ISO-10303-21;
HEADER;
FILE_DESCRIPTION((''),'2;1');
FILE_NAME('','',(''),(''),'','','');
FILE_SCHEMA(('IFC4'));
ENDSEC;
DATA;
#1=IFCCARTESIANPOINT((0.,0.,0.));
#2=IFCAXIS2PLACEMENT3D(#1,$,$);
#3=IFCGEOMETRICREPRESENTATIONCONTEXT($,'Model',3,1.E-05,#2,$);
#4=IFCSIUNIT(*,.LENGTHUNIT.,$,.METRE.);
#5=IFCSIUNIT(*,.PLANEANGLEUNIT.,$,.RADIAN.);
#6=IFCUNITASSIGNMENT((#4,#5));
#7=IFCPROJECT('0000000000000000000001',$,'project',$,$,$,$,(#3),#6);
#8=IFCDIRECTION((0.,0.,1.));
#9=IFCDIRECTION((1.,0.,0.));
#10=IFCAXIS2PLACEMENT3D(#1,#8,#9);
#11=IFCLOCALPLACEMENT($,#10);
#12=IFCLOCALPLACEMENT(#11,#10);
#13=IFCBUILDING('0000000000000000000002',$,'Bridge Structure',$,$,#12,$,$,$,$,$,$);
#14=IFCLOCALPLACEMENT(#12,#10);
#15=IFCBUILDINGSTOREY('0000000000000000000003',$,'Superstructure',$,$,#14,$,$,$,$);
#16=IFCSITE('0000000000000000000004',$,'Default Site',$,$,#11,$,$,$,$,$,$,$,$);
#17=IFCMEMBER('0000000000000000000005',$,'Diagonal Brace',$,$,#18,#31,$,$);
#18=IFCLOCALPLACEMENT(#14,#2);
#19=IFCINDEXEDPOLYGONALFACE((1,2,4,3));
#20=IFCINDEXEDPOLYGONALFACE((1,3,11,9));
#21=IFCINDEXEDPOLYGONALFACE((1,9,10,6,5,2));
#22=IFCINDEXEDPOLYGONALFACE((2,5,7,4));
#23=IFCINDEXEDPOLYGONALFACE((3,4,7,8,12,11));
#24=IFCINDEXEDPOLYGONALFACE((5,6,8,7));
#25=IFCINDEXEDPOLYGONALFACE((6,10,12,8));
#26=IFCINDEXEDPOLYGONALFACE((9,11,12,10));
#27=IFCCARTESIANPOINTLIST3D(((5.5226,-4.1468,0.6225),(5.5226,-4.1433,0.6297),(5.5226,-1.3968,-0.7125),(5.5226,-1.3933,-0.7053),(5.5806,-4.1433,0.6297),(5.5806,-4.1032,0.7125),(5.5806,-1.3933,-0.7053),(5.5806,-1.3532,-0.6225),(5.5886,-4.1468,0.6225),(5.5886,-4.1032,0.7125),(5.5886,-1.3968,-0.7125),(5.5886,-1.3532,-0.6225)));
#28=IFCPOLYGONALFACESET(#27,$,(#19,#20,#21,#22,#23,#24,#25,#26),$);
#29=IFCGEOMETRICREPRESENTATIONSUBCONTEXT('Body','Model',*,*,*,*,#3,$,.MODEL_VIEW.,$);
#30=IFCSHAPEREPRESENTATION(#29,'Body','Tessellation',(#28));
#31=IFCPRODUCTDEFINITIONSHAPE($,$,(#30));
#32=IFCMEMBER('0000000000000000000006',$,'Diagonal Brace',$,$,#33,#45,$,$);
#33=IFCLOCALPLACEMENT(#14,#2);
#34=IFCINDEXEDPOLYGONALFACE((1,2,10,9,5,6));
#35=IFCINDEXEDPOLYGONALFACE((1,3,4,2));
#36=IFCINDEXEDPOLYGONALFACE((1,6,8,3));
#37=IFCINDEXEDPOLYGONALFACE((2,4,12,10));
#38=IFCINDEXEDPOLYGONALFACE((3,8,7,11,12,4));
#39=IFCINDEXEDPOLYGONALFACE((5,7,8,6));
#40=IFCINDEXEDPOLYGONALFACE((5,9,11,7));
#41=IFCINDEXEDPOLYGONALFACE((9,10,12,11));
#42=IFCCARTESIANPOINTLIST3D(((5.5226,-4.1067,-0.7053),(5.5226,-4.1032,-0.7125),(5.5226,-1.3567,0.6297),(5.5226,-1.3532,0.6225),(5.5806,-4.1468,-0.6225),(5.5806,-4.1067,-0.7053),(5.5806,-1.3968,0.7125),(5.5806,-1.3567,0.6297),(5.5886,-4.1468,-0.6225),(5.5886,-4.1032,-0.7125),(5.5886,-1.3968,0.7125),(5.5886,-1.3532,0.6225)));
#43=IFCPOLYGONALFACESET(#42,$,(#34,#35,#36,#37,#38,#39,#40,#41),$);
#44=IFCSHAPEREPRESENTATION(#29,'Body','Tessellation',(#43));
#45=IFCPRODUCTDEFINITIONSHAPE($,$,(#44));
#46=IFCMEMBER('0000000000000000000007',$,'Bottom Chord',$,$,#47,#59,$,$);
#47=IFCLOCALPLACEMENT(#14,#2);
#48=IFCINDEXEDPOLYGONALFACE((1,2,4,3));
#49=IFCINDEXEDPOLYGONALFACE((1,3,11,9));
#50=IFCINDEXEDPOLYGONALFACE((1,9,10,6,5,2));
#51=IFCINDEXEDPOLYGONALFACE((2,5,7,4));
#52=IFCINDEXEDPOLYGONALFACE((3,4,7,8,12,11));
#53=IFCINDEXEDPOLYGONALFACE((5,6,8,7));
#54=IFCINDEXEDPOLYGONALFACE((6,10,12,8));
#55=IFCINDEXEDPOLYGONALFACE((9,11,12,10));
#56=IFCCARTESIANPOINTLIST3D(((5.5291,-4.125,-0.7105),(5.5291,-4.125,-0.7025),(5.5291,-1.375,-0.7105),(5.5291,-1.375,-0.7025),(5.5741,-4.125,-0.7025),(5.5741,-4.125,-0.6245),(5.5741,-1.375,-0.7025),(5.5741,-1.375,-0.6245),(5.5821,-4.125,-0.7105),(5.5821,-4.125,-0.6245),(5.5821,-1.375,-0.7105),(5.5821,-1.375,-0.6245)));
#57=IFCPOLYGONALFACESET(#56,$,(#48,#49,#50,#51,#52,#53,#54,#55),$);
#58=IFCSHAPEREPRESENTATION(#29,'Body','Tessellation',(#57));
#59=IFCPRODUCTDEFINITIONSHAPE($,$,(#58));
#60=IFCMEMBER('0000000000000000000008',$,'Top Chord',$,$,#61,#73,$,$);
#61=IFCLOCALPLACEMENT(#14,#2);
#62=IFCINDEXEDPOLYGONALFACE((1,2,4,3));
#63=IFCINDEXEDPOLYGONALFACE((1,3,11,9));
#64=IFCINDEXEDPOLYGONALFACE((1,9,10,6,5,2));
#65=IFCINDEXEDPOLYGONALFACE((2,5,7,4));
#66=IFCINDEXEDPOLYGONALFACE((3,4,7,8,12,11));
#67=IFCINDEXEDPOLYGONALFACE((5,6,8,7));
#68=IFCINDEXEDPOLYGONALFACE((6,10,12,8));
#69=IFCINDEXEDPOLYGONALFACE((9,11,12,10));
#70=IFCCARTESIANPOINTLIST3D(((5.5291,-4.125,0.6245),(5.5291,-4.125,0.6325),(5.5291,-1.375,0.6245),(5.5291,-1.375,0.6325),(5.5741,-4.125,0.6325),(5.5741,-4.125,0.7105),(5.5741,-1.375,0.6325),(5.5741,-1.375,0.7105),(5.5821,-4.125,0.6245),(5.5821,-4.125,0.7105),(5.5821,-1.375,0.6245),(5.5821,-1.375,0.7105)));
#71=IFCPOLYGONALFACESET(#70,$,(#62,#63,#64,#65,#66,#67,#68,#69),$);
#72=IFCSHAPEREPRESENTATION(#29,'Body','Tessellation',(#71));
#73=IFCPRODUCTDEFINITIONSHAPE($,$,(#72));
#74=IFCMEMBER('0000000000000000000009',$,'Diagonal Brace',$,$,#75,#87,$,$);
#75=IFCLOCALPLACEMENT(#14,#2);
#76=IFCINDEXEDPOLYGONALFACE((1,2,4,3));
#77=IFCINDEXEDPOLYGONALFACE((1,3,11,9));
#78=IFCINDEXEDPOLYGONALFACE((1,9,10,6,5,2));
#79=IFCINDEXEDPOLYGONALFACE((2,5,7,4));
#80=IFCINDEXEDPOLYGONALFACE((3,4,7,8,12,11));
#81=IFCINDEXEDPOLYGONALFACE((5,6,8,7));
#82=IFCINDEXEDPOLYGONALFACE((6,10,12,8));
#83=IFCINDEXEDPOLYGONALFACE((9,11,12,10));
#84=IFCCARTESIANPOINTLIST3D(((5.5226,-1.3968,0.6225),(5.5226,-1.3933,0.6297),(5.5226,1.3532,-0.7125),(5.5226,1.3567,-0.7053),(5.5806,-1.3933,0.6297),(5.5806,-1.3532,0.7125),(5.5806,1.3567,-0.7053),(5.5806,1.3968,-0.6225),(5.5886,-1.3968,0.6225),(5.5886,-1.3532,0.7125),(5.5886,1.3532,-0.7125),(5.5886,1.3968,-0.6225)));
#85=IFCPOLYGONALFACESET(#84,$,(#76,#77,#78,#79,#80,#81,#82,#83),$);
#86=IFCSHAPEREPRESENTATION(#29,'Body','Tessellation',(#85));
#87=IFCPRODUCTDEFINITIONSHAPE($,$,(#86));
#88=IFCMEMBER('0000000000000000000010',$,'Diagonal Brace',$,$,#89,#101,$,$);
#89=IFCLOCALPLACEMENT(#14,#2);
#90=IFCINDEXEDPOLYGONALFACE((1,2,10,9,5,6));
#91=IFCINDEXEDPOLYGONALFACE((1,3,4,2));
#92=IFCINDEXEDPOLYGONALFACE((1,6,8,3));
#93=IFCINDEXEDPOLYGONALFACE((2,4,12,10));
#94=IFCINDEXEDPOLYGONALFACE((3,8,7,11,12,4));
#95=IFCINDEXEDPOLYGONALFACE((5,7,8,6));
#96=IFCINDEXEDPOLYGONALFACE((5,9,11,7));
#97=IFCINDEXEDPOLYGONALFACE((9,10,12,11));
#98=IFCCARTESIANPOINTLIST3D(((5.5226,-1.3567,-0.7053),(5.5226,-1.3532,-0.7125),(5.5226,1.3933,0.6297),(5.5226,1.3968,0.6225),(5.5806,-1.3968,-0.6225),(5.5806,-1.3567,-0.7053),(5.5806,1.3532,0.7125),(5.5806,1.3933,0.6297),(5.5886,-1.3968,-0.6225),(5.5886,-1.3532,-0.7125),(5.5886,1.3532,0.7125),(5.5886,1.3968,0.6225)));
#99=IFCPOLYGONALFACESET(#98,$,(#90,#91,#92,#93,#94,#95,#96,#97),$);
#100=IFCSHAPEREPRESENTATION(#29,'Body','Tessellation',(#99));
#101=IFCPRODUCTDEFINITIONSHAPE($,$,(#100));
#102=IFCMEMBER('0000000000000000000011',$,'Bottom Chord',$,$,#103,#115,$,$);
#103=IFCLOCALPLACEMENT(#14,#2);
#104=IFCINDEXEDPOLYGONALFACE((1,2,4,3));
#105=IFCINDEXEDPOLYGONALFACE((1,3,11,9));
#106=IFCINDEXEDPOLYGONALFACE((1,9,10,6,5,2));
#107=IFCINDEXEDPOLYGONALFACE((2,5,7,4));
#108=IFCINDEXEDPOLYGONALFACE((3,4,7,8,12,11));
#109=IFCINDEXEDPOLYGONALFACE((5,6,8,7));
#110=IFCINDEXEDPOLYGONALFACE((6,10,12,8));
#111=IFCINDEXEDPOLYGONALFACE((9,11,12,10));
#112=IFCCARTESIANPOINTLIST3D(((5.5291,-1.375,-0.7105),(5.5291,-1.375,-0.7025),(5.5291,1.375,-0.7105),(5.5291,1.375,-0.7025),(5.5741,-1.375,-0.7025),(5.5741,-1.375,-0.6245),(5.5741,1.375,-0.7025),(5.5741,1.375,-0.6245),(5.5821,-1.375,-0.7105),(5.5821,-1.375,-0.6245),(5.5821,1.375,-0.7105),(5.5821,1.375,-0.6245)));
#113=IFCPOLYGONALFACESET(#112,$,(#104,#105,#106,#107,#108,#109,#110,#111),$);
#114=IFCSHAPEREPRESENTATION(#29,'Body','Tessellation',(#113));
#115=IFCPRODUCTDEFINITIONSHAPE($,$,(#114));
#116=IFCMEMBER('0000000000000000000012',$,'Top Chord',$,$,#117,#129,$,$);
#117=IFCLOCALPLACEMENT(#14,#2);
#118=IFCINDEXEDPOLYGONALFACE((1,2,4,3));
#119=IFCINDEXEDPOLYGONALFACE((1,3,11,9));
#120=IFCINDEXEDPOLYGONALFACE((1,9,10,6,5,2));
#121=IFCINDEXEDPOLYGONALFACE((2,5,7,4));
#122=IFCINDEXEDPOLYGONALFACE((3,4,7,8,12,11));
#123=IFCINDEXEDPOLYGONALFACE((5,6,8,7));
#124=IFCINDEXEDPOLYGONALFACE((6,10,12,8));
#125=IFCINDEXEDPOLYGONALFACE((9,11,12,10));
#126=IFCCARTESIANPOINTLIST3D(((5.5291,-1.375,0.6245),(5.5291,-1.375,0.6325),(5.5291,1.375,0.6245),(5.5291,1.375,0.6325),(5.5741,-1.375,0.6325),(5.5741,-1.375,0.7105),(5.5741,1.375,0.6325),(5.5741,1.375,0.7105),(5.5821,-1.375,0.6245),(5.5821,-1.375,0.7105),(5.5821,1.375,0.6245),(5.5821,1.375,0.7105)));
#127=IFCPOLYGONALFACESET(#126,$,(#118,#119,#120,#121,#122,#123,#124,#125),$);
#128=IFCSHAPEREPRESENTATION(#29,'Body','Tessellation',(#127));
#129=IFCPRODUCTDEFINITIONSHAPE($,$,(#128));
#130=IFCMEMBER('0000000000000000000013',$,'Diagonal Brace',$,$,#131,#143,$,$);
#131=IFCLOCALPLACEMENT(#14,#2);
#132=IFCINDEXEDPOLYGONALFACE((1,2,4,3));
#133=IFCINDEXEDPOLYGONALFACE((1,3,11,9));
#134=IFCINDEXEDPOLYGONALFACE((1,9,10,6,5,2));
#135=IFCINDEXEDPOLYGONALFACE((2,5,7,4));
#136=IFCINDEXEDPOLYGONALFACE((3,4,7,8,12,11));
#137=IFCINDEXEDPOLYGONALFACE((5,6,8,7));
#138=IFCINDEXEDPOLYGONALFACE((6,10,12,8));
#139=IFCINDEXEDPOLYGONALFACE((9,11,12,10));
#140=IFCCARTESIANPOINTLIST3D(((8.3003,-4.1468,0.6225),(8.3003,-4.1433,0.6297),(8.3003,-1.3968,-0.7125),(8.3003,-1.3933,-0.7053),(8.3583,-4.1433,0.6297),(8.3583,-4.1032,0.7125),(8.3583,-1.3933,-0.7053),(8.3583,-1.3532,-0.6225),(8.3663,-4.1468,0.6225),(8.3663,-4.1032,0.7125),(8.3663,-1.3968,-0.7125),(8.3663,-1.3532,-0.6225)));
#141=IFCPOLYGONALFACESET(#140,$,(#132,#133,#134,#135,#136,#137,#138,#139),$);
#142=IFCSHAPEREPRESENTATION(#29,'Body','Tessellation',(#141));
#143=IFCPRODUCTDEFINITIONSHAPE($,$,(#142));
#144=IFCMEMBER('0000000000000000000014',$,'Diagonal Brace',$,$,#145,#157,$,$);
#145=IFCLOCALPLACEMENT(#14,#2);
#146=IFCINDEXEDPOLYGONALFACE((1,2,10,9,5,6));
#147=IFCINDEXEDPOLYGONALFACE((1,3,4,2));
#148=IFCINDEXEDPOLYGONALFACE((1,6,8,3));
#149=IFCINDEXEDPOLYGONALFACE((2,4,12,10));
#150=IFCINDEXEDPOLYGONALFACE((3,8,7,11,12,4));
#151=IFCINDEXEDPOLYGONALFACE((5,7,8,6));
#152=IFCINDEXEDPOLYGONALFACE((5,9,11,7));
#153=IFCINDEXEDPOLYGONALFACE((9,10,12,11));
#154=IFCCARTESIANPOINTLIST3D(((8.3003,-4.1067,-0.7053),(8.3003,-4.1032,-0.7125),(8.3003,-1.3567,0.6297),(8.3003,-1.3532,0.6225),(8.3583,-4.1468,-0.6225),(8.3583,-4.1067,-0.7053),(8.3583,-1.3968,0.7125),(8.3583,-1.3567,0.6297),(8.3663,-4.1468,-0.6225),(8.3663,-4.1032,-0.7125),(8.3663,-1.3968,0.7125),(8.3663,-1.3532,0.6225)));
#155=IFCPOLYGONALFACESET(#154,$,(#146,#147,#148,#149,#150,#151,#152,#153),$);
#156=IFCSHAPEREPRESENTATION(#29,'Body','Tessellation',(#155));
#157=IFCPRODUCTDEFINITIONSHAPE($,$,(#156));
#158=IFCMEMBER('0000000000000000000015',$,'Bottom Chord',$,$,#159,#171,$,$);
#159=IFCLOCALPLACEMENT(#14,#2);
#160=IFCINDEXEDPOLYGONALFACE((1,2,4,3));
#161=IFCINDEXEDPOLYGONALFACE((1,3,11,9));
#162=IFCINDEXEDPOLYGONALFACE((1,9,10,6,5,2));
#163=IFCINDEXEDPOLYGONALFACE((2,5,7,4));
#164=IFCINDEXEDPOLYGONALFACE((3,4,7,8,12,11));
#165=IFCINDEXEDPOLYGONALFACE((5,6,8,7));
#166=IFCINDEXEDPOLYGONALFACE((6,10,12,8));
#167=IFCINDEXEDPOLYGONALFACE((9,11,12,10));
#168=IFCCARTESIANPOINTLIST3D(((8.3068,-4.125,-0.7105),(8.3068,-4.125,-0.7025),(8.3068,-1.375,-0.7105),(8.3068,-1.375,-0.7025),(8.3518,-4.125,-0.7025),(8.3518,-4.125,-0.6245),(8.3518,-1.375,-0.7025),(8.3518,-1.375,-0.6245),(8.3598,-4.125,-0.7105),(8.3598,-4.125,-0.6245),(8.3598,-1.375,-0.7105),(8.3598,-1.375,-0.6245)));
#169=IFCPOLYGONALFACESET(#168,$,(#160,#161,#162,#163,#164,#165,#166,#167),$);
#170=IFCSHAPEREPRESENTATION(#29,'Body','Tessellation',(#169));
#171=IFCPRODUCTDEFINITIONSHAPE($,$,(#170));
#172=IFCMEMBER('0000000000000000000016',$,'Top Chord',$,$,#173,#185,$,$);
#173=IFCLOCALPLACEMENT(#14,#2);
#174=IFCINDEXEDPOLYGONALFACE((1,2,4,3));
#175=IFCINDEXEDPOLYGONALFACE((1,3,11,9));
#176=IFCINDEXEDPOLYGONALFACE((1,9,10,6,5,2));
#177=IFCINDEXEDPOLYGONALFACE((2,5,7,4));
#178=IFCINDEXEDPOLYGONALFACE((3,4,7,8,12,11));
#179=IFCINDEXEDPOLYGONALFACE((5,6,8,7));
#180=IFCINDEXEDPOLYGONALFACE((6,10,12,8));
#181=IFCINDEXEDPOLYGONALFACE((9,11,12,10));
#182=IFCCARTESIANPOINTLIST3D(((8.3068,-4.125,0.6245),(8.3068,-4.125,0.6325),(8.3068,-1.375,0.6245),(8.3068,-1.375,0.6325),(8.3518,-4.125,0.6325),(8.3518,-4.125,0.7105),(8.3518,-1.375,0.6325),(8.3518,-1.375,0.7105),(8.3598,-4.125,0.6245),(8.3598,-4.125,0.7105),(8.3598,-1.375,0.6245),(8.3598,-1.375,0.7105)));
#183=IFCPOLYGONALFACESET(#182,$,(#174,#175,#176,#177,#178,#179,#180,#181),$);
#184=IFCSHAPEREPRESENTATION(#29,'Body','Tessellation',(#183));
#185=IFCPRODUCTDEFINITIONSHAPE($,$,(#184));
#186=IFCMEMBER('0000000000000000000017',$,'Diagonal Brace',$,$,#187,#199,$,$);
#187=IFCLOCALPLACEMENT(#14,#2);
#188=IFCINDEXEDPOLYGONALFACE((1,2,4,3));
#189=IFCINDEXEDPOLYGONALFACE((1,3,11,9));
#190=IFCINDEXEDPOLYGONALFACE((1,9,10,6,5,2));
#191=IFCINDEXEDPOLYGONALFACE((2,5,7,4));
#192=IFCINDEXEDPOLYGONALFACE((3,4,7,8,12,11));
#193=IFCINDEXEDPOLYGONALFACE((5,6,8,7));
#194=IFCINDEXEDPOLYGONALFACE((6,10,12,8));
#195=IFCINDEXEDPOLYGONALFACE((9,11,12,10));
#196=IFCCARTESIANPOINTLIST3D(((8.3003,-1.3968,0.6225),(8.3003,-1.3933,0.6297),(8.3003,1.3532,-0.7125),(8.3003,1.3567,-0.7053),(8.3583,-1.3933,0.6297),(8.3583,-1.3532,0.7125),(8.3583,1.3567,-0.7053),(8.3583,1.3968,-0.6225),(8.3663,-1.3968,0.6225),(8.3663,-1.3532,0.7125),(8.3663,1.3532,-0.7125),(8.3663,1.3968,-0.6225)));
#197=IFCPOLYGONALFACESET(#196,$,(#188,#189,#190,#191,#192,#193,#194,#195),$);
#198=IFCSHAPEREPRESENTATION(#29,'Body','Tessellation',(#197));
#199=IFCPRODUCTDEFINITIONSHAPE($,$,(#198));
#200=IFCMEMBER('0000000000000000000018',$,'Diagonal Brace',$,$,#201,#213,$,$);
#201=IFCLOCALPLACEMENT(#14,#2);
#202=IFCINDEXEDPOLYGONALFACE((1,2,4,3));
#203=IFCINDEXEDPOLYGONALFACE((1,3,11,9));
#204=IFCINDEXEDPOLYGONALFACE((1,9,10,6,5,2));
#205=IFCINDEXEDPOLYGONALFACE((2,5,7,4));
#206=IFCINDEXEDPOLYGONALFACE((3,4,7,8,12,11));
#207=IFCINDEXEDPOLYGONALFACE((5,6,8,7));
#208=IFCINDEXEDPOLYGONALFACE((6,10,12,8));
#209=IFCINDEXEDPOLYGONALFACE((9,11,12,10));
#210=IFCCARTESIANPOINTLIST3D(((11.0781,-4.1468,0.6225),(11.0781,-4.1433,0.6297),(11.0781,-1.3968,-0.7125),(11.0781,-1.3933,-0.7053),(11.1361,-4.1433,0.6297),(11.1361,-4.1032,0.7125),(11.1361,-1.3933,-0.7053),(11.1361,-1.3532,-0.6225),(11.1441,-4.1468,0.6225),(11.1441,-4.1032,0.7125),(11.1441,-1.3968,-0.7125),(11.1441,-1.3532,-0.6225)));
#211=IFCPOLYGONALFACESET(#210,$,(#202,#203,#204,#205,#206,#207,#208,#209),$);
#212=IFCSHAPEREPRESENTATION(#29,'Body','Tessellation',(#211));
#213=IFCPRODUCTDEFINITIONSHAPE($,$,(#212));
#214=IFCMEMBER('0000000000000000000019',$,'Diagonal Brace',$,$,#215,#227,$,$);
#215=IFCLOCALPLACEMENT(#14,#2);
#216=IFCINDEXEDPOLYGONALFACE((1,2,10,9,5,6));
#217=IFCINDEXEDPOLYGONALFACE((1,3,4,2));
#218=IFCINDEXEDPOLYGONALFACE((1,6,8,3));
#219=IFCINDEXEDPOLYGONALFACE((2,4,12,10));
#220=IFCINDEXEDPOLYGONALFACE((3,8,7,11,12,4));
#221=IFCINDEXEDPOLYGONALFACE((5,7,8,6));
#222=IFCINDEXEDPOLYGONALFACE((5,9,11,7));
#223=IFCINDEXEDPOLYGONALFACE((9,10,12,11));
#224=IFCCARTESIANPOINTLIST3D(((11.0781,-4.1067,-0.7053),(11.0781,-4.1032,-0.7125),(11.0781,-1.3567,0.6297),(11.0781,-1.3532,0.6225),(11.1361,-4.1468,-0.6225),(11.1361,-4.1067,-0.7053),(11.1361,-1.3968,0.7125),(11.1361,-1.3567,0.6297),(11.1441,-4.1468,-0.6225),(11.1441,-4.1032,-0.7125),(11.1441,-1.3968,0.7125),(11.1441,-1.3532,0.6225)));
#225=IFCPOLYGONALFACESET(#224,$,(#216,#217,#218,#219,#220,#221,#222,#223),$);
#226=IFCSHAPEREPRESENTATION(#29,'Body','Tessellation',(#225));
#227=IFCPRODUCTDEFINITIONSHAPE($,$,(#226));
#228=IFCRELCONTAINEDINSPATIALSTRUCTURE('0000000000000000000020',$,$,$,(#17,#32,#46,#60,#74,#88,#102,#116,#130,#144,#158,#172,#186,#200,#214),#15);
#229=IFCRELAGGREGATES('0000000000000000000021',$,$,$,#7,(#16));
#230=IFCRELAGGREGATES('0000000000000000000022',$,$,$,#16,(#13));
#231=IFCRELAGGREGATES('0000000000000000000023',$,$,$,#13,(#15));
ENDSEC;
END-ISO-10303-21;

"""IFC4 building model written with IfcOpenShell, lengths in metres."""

from ifc_helpers import new_model, si_unit, frame, origin, origin_with_axes, origin_2d_with_axis, place, context, subcontext, project, spatial, l_section, extrude, element, save


model = new_model("IFC4")

# Units and contexts
model_context = context("Model", 3, precision=1e-05, world=origin())
body_context = subcontext(model_context, "Body", "Model", "MODEL_VIEW")
ifc_project = project(units=[si_unit("LENGTHUNIT", "METRE"), si_unit("PLANEANGLEUNIT", "RADIAN")], contexts=[model_context])

# Site, building, storey
site_placement = place(None, origin_with_axes())
site = spatial("IfcSite", under=ifc_project, at=site_placement, Name="Default Site")
building_placement = place(site_placement, origin_with_axes())
building = spatial("IfcBuilding", under=site, at=building_placement, Name="Bridge Structure")
storey_placement = place(building_placement, origin_with_axes())
storey = spatial("IfcBuildingStorey", under=building, at=storey_placement, Name="Superstructure")

# Members
for number, where, z_axis, x_axis, name in (
    (1, (5.5556, -4.125, 0.6675), (0.0, 0.8996, -0.436715), (-1.0, 0.0, 0.0), "Diagonal Brace"),
    (2, (5.5556, -4.125, -0.6675), (0.0, 0.8996, 0.436715), (-1.0, 0.0, 0.0), "Diagonal Brace"),
):
    element("IfcMember", number, at=place(storey_placement, frame(where, z_axis=z_axis, x_axis=x_axis)), inside=storey, Name=name, context=body_context, shape_type="SweptSolid", body=[
        extrude(l_section(Depth=0.1, Width=0.066, Thickness=0.008, at=origin_2d_with_axis()), origin_with_axes(), (0.0, 0.0, 1.0), 3.0569),
    ])
for number, where, z_axis, x_axis, name in (
    (3, (5.5556, -4.125, -0.6675), (0.0, 1.0, 0.0), (-1.0, 0.0, 0.0), "Bottom Chord"),
    (4, (5.5556, -4.125, 0.6675), (0.0, 1.0, 0.0), (-1.0, 0.0, 0.0), "Top Chord"),
):
    element("IfcMember", number, at=place(storey_placement, frame(where, z_axis=z_axis, x_axis=x_axis)), inside=storey, Name=name, context=body_context, shape_type="SweptSolid", body=[
        extrude(l_section(Depth=0.086, Width=0.053, Thickness=0.008, at=origin_2d_with_axis()), origin_with_axes(), (0.0, 0.0, 1.0), 2.75),
    ])
for number, where, z_axis, x_axis, name in (
    (5, (5.5556, -1.375, 0.6675), (0.0, 0.8996, -0.436715), (-1.0, 0.0, 0.0), "Diagonal Brace"),
    (6, (5.5556, -1.375, -0.6675), (0.0, 0.8996, 0.436715), (-1.0, 0.0, 0.0), "Diagonal Brace"),
):
    element("IfcMember", number, at=place(storey_placement, frame(where, z_axis=z_axis, x_axis=x_axis)), inside=storey, Name=name, context=body_context, shape_type="SweptSolid", body=[
        extrude(l_section(Depth=0.1, Width=0.066, Thickness=0.008, at=origin_2d_with_axis()), origin_with_axes(), (0.0, 0.0, 1.0), 3.0569),
    ])
for number, where, z_axis, x_axis, name in (
    (7, (5.5556, -1.375, -0.6675), (0.0, 1.0, 0.0), (-1.0, 0.0, 0.0), "Bottom Chord"),
    (8, (5.5556, -1.375, 0.6675), (0.0, 1.0, 0.0), (-1.0, 0.0, 0.0), "Top Chord"),
):
    element("IfcMember", number, at=place(storey_placement, frame(where, z_axis=z_axis, x_axis=x_axis)), inside=storey, Name=name, context=body_context, shape_type="SweptSolid", body=[
        extrude(l_section(Depth=0.086, Width=0.053, Thickness=0.008, at=origin_2d_with_axis()), origin_with_axes(), (0.0, 0.0, 1.0), 2.75),
    ])
for number, where, z_axis, x_axis, name in (
    (9, (8.3333, -4.125, 0.6675), (0.0, 0.8996, -0.436715), (-1.0, 0.0, 0.0), "Diagonal Brace"),
    (10, (8.3333, -4.125, -0.6675), (0.0, 0.8996, 0.436715), (-1.0, 0.0, 0.0), "Diagonal Brace"),
):
    element("IfcMember", number, at=place(storey_placement, frame(where, z_axis=z_axis, x_axis=x_axis)), inside=storey, Name=name, context=body_context, shape_type="SweptSolid", body=[
        extrude(l_section(Depth=0.1, Width=0.066, Thickness=0.008, at=origin_2d_with_axis()), origin_with_axes(), (0.0, 0.0, 1.0), 3.0569),
    ])
for number, where, z_axis, x_axis, name in (
    (11, (8.3333, -4.125, -0.6675), (0.0, 1.0, 0.0), (-1.0, 0.0, 0.0), "Bottom Chord"),
    (12, (8.3333, -4.125, 0.6675), (0.0, 1.0, 0.0), (-1.0, 0.0, 0.0), "Top Chord"),
):
    element("IfcMember", number, at=place(storey_placement, frame(where, z_axis=z_axis, x_axis=x_axis)), inside=storey, Name=name, context=body_context, shape_type="SweptSolid", body=[
        extrude(l_section(Depth=0.086, Width=0.053, Thickness=0.008, at=origin_2d_with_axis()), origin_with_axes(), (0.0, 0.0, 1.0), 2.75),
    ])
for number, where, z_axis, x_axis, name in (
    (13, (8.3333, -1.375, 0.6675), (0.0, 0.8996, -0.436715), (-1.0, 0.0, 0.0), "Diagonal Brace"),
    (14, (11.1111, -4.125, 0.6675), (0.0, 0.8996, -0.436715), (-1.0, 0.0, 0.0), "Diagonal Brace"),
    (15, (11.1111, -4.125, -0.6675), (0.0, 0.8996, 0.436715), (-1.0, 0.0, 0.0), "Diagonal Brace"),
):
    element("IfcMember", number, at=place(storey_placement, frame(where, z_axis=z_axis, x_axis=x_axis)), inside=storey, Name=name, context=body_context, shape_type="SweptSolid", body=[
        extrude(l_section(Depth=0.1, Width=0.066, Thickness=0.008, at=origin_2d_with_axis()), origin_with_axes(), (0.0, 0.0, 1.0), 3.0569),
    ])

save(model, "model.ifc")
